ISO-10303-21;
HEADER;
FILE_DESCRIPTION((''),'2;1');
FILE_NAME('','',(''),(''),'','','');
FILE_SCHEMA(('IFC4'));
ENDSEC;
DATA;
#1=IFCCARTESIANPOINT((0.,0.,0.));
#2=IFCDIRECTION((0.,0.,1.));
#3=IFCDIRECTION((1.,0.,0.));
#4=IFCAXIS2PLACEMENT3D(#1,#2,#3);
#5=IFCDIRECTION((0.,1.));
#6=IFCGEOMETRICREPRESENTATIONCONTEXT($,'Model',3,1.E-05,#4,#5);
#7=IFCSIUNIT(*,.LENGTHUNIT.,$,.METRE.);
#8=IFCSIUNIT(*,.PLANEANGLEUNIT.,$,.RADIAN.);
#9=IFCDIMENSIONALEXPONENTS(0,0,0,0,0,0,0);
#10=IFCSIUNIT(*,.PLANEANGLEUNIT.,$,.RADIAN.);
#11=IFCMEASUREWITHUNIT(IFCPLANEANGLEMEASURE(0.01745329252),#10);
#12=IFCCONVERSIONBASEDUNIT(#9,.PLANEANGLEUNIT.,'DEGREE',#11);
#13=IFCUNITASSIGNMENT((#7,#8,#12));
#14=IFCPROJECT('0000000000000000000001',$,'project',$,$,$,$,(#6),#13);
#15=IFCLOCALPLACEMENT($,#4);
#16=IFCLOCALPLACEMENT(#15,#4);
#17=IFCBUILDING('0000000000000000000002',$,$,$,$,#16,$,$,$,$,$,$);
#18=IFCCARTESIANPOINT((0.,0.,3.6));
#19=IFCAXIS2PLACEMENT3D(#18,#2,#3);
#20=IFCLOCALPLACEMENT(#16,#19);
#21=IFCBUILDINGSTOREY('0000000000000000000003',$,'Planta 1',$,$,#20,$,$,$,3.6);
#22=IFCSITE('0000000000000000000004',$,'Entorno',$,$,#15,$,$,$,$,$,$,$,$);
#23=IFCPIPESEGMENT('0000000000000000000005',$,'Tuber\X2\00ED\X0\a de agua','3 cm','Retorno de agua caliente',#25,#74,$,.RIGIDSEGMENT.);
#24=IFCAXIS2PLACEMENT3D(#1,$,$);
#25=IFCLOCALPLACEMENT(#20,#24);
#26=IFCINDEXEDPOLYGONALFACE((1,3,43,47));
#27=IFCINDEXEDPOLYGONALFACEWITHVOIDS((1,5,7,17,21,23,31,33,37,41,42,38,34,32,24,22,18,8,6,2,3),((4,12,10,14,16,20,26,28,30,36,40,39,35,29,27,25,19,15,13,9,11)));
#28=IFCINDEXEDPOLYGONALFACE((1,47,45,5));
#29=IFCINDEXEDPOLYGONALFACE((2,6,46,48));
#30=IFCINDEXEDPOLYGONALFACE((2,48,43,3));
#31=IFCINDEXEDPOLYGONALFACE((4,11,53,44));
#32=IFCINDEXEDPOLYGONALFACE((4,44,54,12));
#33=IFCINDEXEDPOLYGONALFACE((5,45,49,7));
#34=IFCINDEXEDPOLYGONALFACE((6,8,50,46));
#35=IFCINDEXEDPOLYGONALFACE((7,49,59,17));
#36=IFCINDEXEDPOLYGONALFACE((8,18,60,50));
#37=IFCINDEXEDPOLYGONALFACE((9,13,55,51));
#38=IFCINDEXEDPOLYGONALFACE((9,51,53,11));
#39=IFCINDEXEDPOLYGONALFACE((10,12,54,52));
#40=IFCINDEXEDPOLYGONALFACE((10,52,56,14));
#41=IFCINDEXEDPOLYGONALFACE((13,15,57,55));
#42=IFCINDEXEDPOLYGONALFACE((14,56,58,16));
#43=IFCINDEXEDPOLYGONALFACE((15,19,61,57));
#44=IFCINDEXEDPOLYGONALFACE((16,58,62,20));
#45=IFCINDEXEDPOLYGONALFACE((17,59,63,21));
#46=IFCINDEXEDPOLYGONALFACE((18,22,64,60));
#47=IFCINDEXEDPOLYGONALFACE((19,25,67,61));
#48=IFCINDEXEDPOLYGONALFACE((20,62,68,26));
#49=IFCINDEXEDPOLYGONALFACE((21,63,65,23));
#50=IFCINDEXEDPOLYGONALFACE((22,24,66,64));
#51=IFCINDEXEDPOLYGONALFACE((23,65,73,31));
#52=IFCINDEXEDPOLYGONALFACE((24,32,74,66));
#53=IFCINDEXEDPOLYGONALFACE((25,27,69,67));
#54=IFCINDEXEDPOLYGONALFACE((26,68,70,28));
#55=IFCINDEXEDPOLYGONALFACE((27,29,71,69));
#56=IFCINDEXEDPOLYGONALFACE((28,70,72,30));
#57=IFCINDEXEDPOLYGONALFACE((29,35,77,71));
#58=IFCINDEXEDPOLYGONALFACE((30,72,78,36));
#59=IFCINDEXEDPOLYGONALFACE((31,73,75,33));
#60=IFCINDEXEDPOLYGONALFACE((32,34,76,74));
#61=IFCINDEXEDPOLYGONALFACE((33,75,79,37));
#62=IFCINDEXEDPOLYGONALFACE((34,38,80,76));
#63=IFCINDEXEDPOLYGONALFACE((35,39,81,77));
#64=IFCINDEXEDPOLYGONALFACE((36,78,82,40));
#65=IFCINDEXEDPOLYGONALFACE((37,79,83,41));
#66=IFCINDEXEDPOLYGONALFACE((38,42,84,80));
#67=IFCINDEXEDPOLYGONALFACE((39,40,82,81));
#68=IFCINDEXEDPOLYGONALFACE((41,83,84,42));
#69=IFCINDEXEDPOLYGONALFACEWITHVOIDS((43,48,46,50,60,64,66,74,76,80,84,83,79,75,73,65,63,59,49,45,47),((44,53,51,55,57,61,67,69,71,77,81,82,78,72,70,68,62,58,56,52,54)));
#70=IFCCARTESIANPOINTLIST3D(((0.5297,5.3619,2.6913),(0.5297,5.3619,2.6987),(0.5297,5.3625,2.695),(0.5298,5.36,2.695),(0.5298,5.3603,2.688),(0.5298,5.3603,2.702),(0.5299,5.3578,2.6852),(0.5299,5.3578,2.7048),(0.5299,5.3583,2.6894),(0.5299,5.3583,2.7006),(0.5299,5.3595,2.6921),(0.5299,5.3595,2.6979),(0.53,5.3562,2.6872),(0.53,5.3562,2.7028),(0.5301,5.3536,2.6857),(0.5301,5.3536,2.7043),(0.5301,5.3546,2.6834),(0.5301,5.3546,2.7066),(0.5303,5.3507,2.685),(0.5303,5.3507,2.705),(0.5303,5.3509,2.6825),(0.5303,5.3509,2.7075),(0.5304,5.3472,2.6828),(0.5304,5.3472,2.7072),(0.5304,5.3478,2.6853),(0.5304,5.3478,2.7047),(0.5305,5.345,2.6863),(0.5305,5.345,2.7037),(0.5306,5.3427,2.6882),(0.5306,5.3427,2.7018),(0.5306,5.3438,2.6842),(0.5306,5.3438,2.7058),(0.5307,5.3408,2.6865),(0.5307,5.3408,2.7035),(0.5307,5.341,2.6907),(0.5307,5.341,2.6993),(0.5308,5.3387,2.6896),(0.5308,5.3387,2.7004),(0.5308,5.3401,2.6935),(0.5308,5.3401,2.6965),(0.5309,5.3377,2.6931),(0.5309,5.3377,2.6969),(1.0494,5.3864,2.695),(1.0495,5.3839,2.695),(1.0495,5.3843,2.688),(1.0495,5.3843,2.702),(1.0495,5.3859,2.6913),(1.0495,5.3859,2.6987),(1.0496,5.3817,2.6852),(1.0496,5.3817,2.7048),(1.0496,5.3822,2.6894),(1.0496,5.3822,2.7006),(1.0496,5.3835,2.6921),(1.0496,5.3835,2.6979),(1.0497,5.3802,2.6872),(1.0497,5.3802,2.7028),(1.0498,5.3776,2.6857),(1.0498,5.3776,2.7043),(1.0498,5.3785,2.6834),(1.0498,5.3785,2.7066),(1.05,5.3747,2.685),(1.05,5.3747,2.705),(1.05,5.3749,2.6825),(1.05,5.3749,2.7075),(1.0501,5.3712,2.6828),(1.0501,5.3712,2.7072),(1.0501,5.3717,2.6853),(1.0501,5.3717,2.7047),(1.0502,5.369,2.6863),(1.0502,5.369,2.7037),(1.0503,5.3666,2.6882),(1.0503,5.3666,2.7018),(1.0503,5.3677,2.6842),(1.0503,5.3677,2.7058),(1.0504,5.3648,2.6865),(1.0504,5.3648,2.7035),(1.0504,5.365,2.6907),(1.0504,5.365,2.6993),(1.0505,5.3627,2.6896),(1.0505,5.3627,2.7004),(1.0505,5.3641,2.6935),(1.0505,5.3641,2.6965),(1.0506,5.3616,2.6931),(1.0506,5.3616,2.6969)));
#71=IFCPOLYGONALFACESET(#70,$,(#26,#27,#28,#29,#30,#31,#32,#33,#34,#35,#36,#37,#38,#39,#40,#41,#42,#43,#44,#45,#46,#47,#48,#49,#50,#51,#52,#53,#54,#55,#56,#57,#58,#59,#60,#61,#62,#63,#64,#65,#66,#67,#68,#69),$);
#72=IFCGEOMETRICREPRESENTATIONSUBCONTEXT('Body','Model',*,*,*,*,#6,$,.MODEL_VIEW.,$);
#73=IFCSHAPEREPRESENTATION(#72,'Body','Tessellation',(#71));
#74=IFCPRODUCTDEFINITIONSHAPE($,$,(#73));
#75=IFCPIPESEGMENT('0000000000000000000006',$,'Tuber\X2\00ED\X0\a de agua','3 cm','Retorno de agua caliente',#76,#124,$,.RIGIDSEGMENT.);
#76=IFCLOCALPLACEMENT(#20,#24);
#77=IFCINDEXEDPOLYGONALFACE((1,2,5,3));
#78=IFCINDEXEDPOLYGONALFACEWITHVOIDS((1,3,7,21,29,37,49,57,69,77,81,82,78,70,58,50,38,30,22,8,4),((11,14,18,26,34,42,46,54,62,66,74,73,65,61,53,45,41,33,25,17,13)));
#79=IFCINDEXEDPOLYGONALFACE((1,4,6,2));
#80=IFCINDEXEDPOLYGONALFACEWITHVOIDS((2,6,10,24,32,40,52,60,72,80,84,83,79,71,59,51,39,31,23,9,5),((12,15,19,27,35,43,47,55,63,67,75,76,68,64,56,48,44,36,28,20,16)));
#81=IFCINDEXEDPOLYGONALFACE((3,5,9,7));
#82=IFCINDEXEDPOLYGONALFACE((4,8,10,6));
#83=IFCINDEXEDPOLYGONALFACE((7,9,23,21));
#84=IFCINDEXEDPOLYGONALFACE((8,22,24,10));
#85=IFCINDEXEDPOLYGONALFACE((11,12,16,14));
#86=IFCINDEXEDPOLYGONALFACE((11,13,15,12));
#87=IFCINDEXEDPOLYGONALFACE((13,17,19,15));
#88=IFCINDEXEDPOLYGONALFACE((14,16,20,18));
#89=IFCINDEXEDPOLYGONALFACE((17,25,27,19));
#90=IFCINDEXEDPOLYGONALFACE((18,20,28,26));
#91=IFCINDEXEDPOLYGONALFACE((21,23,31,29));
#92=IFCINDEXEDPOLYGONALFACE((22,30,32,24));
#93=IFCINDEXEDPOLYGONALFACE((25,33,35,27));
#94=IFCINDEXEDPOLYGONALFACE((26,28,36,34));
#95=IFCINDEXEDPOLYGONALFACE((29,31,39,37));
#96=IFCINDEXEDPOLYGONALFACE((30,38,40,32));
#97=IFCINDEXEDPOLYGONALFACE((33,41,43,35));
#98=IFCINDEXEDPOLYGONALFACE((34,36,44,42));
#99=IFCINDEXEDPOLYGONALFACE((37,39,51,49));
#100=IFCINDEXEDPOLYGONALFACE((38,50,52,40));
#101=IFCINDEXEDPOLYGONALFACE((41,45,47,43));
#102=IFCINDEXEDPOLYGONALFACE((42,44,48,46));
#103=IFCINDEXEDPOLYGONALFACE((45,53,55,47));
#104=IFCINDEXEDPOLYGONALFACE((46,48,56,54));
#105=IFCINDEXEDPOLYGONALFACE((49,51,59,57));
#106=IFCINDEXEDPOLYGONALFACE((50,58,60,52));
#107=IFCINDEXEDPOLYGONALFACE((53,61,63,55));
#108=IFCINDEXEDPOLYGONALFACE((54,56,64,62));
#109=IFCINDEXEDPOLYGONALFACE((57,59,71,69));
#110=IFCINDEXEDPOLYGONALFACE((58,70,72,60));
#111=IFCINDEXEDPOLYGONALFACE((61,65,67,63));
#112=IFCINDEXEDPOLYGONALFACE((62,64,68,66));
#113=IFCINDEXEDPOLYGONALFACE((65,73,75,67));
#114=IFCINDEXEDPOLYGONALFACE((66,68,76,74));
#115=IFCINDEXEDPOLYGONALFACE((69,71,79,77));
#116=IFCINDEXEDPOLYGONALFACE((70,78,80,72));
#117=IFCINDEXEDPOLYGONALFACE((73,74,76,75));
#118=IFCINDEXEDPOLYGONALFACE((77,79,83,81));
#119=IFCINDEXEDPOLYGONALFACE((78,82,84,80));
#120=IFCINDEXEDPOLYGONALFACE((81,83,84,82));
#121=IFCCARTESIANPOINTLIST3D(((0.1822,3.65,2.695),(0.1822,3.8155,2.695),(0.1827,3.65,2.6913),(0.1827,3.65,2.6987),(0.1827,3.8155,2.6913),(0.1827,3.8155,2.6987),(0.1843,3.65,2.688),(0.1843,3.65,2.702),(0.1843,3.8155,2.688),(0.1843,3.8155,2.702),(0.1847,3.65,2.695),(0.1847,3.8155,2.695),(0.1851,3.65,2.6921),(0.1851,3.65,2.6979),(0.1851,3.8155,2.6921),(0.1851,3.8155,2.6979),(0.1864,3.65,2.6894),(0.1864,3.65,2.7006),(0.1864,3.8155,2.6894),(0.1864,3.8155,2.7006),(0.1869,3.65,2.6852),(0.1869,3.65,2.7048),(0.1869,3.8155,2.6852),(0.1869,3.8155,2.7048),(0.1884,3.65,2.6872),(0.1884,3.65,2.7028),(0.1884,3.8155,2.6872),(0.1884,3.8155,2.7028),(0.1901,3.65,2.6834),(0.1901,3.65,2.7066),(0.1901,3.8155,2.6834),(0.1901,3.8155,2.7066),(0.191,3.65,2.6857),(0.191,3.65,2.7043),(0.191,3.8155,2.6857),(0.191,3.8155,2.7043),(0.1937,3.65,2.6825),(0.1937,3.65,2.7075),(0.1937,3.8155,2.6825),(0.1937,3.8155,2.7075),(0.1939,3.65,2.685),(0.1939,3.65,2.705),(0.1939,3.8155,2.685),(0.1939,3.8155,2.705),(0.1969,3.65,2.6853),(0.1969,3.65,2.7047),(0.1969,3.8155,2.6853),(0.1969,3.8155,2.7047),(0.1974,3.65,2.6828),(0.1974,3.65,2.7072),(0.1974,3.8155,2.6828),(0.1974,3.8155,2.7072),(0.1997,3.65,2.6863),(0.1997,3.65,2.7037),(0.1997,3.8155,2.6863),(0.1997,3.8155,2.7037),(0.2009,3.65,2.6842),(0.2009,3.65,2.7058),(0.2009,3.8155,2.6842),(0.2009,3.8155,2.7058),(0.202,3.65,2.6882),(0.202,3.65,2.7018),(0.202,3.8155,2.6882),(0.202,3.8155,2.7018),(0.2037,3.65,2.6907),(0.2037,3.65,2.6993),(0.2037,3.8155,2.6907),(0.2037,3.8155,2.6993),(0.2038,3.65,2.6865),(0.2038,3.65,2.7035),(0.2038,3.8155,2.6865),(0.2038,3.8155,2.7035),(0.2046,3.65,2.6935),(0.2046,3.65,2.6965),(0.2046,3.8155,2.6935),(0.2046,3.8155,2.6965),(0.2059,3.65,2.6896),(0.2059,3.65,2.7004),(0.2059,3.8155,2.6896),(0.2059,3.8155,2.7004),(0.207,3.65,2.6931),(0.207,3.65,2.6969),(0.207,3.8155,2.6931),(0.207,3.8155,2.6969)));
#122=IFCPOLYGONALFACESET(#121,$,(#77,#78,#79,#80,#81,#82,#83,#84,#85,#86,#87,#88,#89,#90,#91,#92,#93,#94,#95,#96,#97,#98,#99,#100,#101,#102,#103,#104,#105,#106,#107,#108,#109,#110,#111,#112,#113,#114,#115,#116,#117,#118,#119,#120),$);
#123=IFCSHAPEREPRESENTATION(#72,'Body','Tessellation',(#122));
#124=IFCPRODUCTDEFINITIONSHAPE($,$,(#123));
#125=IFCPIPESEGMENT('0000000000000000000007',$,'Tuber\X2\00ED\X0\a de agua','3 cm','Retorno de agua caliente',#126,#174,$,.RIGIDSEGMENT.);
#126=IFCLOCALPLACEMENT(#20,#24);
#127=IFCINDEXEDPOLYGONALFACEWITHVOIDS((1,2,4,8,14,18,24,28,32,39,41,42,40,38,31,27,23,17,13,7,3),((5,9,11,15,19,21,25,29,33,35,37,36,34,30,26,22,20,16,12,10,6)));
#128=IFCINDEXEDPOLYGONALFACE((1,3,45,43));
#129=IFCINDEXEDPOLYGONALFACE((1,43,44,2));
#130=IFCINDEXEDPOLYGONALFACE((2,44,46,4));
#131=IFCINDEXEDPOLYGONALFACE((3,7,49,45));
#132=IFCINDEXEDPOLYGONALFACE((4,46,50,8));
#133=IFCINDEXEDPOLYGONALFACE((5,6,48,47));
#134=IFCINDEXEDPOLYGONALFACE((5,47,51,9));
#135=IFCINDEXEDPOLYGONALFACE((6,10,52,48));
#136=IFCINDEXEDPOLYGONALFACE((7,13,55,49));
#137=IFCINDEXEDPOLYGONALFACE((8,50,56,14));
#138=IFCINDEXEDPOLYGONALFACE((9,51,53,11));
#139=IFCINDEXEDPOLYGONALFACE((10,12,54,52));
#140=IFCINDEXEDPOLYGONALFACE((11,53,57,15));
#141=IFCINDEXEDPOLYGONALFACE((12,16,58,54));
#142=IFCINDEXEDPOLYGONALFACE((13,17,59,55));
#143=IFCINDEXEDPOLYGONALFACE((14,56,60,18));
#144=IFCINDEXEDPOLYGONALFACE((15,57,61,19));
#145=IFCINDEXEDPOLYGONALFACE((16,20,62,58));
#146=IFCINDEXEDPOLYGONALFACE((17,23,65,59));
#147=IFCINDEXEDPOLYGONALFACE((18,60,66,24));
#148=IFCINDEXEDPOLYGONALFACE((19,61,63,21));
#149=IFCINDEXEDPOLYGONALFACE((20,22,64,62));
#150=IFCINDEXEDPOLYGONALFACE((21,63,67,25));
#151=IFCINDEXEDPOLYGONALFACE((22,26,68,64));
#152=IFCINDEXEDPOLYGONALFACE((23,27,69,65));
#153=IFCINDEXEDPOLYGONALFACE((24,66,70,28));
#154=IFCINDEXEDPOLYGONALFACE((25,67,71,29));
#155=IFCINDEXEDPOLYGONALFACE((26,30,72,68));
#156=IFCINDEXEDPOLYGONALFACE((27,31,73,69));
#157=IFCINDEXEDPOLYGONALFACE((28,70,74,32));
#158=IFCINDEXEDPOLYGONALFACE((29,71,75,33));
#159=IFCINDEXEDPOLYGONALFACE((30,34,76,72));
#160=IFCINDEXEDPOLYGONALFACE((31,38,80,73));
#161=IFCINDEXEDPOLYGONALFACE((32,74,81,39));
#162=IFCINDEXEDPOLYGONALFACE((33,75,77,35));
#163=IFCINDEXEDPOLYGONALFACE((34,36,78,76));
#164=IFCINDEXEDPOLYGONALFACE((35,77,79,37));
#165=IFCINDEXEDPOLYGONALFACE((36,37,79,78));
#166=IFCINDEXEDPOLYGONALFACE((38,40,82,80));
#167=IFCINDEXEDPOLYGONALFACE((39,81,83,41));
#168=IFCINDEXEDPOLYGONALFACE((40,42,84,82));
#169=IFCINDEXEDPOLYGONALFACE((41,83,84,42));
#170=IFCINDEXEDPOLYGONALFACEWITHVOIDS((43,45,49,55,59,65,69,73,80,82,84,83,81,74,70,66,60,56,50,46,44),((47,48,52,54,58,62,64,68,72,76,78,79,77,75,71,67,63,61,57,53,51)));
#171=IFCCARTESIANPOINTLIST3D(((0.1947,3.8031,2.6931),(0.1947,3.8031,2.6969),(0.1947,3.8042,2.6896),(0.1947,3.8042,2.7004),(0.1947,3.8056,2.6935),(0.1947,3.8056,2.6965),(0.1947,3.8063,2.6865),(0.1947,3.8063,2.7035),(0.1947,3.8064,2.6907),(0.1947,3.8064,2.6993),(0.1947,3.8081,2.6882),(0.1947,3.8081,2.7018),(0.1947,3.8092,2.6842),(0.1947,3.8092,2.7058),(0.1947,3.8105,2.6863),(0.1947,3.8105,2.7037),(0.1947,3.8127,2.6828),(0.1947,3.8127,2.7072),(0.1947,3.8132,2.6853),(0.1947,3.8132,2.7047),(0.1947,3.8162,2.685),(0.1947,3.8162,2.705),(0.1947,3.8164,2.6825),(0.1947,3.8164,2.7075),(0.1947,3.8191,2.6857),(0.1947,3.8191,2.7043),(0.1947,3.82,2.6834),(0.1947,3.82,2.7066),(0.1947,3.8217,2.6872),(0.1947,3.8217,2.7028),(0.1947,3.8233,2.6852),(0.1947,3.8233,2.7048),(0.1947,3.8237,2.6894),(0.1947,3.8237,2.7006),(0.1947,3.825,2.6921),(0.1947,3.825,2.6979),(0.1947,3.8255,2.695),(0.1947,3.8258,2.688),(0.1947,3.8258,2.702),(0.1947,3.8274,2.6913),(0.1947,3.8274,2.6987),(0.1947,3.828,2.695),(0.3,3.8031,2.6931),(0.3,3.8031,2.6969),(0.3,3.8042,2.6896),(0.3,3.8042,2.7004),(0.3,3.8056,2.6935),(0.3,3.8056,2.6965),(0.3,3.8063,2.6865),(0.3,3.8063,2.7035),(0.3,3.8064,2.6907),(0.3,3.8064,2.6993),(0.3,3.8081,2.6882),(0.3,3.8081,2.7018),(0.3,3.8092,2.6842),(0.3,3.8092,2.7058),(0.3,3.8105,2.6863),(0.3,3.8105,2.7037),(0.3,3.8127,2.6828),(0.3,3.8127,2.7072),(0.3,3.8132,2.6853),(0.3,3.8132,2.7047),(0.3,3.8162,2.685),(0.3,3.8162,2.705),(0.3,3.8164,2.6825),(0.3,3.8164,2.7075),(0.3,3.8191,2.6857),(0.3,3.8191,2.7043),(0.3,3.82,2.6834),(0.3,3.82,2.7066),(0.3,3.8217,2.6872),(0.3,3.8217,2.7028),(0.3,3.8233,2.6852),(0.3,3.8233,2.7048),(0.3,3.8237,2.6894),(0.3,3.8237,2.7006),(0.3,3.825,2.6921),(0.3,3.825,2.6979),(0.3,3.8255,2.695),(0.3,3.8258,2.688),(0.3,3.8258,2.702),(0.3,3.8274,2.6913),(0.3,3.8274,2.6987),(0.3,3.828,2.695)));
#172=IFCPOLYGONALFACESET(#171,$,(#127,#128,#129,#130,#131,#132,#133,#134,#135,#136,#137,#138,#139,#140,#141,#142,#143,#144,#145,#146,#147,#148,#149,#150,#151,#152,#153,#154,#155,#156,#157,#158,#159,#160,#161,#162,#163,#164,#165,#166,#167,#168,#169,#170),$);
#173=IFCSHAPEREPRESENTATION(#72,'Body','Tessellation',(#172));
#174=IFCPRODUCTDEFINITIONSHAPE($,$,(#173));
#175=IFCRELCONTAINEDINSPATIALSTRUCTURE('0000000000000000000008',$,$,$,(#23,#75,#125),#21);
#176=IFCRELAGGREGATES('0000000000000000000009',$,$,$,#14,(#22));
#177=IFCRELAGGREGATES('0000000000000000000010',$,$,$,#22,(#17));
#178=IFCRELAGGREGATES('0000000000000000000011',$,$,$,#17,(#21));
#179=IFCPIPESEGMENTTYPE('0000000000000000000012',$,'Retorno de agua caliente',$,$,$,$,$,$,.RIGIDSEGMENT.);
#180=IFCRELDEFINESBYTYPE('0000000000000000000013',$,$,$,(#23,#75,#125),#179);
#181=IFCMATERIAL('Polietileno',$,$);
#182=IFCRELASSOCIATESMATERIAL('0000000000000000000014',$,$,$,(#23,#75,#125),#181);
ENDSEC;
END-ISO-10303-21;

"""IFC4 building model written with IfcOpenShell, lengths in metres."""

from ifc_helpers import new_model, entity, si_unit, converted_unit, direction, frame, origin_with_axes, origin_2d_with_axis, place, context, subcontext, project, spatial, hollow_circle, extrude, material, type_object, element, save


model = new_model("IFC4")

# Units and contexts
model_context = context("Model", 3, precision=1e-05, world=origin_with_axes(), true_north=direction((0.0, 1.0)))
body_context = subcontext(model_context, "Body", "Model", "MODEL_VIEW")
ifc_project = project(units=[si_unit("LENGTHUNIT", "METRE"), si_unit("PLANEANGLEUNIT", "RADIAN"), converted_unit("PLANEANGLEUNIT", "DEGREE", entity("IfcPlaneAngleMeasure", 0.01745329252), si_unit("PLANEANGLEUNIT", "RADIAN"), dimensions=[0, 0, 0, 0, 0, 0, 0])], contexts=[model_context])

# Site, building, storey
site_placement = place(None, origin_with_axes())
site = spatial("IfcSite", under=ifc_project, at=site_placement, Name="Entorno")
building_placement = place(site_placement, origin_with_axes())
building = spatial("IfcBuilding", under=site, at=building_placement)
storey_placement = place(building_placement, frame((0.0, 0.0, 3.6), z_axis=(0.0, 0.0, 1.0), x_axis=(1.0, 0.0, 0.0)))
storey = spatial("IfcBuildingStorey", under=building, at=storey_placement, Name="Planta 1", Elevation=3.6)

# Pipe segments
ifc_material_1 = material(Name="Polietileno")
pipe_segment_type_1 = type_object("IfcPipeSegmentType", Name="Retorno de agua caliente", PredefinedType="RIGIDSEGMENT")
pipe_segment_1_placement = place(storey_placement, frame((0.5303, 5.35, 2.695), z_axis=(0.99894, 0.046036, 0.0), x_axis=(-0.046036, 0.99894, 0.0)))
element("IfcPipeSegment", 1, at=pipe_segment_1_placement, inside=storey, type_object=pipe_segment_type_1, material=ifc_material_1, Name="Tubería de agua", Description="3 cm", ObjectType="Retorno de agua caliente", PredefinedType="RIGIDSEGMENT", context=body_context, shape_type="SweptSolid", body=[
    extrude(hollow_circle(Radius=0.0125, WallThickness=0.0025, at=origin_2d_with_axis()), origin_with_axes(), (0.0, 0.0, 1.0), 0.5203),
])
pipe_segment_2_placement = place(storey_placement, frame((0.1947, 3.65, 2.695), z_axis=(0.0, 1.0, 0.0), x_axis=(-1.0, 0.0, 0.0)))
element("IfcPipeSegment", 2, at=pipe_segment_2_placement, inside=storey, type_object=pipe_segment_type_1, material=ifc_material_1, Name="Tubería de agua", Description="3 cm", ObjectType="Retorno de agua caliente", PredefinedType="RIGIDSEGMENT", context=body_context, shape_type="SweptSolid", body=[
    extrude(hollow_circle(Radius=0.0125, WallThickness=0.0025, at=origin_2d_with_axis()), origin_with_axes(), (0.0, 0.0, 1.0), 0.1655),
])
pipe_segment_3_placement = place(storey_placement, frame((0.1947, 3.8155, 2.695), z_axis=(1.0, 0.0, 0.0), x_axis=(0.0, 1.0, 0.0)))
element("IfcPipeSegment", 3, at=pipe_segment_3_placement, inside=storey, type_object=pipe_segment_type_1, material=ifc_material_1, Name="Tubería de agua", Description="3 cm", ObjectType="Retorno de agua caliente", PredefinedType="RIGIDSEGMENT", context=body_context, shape_type="SweptSolid", body=[
    extrude(hollow_circle(Radius=0.0125, WallThickness=0.0025, at=origin_2d_with_axis()), origin_with_axes(), (0.0, 0.0, 1.0), 0.1053),
])

save(model, "model.ifc")
